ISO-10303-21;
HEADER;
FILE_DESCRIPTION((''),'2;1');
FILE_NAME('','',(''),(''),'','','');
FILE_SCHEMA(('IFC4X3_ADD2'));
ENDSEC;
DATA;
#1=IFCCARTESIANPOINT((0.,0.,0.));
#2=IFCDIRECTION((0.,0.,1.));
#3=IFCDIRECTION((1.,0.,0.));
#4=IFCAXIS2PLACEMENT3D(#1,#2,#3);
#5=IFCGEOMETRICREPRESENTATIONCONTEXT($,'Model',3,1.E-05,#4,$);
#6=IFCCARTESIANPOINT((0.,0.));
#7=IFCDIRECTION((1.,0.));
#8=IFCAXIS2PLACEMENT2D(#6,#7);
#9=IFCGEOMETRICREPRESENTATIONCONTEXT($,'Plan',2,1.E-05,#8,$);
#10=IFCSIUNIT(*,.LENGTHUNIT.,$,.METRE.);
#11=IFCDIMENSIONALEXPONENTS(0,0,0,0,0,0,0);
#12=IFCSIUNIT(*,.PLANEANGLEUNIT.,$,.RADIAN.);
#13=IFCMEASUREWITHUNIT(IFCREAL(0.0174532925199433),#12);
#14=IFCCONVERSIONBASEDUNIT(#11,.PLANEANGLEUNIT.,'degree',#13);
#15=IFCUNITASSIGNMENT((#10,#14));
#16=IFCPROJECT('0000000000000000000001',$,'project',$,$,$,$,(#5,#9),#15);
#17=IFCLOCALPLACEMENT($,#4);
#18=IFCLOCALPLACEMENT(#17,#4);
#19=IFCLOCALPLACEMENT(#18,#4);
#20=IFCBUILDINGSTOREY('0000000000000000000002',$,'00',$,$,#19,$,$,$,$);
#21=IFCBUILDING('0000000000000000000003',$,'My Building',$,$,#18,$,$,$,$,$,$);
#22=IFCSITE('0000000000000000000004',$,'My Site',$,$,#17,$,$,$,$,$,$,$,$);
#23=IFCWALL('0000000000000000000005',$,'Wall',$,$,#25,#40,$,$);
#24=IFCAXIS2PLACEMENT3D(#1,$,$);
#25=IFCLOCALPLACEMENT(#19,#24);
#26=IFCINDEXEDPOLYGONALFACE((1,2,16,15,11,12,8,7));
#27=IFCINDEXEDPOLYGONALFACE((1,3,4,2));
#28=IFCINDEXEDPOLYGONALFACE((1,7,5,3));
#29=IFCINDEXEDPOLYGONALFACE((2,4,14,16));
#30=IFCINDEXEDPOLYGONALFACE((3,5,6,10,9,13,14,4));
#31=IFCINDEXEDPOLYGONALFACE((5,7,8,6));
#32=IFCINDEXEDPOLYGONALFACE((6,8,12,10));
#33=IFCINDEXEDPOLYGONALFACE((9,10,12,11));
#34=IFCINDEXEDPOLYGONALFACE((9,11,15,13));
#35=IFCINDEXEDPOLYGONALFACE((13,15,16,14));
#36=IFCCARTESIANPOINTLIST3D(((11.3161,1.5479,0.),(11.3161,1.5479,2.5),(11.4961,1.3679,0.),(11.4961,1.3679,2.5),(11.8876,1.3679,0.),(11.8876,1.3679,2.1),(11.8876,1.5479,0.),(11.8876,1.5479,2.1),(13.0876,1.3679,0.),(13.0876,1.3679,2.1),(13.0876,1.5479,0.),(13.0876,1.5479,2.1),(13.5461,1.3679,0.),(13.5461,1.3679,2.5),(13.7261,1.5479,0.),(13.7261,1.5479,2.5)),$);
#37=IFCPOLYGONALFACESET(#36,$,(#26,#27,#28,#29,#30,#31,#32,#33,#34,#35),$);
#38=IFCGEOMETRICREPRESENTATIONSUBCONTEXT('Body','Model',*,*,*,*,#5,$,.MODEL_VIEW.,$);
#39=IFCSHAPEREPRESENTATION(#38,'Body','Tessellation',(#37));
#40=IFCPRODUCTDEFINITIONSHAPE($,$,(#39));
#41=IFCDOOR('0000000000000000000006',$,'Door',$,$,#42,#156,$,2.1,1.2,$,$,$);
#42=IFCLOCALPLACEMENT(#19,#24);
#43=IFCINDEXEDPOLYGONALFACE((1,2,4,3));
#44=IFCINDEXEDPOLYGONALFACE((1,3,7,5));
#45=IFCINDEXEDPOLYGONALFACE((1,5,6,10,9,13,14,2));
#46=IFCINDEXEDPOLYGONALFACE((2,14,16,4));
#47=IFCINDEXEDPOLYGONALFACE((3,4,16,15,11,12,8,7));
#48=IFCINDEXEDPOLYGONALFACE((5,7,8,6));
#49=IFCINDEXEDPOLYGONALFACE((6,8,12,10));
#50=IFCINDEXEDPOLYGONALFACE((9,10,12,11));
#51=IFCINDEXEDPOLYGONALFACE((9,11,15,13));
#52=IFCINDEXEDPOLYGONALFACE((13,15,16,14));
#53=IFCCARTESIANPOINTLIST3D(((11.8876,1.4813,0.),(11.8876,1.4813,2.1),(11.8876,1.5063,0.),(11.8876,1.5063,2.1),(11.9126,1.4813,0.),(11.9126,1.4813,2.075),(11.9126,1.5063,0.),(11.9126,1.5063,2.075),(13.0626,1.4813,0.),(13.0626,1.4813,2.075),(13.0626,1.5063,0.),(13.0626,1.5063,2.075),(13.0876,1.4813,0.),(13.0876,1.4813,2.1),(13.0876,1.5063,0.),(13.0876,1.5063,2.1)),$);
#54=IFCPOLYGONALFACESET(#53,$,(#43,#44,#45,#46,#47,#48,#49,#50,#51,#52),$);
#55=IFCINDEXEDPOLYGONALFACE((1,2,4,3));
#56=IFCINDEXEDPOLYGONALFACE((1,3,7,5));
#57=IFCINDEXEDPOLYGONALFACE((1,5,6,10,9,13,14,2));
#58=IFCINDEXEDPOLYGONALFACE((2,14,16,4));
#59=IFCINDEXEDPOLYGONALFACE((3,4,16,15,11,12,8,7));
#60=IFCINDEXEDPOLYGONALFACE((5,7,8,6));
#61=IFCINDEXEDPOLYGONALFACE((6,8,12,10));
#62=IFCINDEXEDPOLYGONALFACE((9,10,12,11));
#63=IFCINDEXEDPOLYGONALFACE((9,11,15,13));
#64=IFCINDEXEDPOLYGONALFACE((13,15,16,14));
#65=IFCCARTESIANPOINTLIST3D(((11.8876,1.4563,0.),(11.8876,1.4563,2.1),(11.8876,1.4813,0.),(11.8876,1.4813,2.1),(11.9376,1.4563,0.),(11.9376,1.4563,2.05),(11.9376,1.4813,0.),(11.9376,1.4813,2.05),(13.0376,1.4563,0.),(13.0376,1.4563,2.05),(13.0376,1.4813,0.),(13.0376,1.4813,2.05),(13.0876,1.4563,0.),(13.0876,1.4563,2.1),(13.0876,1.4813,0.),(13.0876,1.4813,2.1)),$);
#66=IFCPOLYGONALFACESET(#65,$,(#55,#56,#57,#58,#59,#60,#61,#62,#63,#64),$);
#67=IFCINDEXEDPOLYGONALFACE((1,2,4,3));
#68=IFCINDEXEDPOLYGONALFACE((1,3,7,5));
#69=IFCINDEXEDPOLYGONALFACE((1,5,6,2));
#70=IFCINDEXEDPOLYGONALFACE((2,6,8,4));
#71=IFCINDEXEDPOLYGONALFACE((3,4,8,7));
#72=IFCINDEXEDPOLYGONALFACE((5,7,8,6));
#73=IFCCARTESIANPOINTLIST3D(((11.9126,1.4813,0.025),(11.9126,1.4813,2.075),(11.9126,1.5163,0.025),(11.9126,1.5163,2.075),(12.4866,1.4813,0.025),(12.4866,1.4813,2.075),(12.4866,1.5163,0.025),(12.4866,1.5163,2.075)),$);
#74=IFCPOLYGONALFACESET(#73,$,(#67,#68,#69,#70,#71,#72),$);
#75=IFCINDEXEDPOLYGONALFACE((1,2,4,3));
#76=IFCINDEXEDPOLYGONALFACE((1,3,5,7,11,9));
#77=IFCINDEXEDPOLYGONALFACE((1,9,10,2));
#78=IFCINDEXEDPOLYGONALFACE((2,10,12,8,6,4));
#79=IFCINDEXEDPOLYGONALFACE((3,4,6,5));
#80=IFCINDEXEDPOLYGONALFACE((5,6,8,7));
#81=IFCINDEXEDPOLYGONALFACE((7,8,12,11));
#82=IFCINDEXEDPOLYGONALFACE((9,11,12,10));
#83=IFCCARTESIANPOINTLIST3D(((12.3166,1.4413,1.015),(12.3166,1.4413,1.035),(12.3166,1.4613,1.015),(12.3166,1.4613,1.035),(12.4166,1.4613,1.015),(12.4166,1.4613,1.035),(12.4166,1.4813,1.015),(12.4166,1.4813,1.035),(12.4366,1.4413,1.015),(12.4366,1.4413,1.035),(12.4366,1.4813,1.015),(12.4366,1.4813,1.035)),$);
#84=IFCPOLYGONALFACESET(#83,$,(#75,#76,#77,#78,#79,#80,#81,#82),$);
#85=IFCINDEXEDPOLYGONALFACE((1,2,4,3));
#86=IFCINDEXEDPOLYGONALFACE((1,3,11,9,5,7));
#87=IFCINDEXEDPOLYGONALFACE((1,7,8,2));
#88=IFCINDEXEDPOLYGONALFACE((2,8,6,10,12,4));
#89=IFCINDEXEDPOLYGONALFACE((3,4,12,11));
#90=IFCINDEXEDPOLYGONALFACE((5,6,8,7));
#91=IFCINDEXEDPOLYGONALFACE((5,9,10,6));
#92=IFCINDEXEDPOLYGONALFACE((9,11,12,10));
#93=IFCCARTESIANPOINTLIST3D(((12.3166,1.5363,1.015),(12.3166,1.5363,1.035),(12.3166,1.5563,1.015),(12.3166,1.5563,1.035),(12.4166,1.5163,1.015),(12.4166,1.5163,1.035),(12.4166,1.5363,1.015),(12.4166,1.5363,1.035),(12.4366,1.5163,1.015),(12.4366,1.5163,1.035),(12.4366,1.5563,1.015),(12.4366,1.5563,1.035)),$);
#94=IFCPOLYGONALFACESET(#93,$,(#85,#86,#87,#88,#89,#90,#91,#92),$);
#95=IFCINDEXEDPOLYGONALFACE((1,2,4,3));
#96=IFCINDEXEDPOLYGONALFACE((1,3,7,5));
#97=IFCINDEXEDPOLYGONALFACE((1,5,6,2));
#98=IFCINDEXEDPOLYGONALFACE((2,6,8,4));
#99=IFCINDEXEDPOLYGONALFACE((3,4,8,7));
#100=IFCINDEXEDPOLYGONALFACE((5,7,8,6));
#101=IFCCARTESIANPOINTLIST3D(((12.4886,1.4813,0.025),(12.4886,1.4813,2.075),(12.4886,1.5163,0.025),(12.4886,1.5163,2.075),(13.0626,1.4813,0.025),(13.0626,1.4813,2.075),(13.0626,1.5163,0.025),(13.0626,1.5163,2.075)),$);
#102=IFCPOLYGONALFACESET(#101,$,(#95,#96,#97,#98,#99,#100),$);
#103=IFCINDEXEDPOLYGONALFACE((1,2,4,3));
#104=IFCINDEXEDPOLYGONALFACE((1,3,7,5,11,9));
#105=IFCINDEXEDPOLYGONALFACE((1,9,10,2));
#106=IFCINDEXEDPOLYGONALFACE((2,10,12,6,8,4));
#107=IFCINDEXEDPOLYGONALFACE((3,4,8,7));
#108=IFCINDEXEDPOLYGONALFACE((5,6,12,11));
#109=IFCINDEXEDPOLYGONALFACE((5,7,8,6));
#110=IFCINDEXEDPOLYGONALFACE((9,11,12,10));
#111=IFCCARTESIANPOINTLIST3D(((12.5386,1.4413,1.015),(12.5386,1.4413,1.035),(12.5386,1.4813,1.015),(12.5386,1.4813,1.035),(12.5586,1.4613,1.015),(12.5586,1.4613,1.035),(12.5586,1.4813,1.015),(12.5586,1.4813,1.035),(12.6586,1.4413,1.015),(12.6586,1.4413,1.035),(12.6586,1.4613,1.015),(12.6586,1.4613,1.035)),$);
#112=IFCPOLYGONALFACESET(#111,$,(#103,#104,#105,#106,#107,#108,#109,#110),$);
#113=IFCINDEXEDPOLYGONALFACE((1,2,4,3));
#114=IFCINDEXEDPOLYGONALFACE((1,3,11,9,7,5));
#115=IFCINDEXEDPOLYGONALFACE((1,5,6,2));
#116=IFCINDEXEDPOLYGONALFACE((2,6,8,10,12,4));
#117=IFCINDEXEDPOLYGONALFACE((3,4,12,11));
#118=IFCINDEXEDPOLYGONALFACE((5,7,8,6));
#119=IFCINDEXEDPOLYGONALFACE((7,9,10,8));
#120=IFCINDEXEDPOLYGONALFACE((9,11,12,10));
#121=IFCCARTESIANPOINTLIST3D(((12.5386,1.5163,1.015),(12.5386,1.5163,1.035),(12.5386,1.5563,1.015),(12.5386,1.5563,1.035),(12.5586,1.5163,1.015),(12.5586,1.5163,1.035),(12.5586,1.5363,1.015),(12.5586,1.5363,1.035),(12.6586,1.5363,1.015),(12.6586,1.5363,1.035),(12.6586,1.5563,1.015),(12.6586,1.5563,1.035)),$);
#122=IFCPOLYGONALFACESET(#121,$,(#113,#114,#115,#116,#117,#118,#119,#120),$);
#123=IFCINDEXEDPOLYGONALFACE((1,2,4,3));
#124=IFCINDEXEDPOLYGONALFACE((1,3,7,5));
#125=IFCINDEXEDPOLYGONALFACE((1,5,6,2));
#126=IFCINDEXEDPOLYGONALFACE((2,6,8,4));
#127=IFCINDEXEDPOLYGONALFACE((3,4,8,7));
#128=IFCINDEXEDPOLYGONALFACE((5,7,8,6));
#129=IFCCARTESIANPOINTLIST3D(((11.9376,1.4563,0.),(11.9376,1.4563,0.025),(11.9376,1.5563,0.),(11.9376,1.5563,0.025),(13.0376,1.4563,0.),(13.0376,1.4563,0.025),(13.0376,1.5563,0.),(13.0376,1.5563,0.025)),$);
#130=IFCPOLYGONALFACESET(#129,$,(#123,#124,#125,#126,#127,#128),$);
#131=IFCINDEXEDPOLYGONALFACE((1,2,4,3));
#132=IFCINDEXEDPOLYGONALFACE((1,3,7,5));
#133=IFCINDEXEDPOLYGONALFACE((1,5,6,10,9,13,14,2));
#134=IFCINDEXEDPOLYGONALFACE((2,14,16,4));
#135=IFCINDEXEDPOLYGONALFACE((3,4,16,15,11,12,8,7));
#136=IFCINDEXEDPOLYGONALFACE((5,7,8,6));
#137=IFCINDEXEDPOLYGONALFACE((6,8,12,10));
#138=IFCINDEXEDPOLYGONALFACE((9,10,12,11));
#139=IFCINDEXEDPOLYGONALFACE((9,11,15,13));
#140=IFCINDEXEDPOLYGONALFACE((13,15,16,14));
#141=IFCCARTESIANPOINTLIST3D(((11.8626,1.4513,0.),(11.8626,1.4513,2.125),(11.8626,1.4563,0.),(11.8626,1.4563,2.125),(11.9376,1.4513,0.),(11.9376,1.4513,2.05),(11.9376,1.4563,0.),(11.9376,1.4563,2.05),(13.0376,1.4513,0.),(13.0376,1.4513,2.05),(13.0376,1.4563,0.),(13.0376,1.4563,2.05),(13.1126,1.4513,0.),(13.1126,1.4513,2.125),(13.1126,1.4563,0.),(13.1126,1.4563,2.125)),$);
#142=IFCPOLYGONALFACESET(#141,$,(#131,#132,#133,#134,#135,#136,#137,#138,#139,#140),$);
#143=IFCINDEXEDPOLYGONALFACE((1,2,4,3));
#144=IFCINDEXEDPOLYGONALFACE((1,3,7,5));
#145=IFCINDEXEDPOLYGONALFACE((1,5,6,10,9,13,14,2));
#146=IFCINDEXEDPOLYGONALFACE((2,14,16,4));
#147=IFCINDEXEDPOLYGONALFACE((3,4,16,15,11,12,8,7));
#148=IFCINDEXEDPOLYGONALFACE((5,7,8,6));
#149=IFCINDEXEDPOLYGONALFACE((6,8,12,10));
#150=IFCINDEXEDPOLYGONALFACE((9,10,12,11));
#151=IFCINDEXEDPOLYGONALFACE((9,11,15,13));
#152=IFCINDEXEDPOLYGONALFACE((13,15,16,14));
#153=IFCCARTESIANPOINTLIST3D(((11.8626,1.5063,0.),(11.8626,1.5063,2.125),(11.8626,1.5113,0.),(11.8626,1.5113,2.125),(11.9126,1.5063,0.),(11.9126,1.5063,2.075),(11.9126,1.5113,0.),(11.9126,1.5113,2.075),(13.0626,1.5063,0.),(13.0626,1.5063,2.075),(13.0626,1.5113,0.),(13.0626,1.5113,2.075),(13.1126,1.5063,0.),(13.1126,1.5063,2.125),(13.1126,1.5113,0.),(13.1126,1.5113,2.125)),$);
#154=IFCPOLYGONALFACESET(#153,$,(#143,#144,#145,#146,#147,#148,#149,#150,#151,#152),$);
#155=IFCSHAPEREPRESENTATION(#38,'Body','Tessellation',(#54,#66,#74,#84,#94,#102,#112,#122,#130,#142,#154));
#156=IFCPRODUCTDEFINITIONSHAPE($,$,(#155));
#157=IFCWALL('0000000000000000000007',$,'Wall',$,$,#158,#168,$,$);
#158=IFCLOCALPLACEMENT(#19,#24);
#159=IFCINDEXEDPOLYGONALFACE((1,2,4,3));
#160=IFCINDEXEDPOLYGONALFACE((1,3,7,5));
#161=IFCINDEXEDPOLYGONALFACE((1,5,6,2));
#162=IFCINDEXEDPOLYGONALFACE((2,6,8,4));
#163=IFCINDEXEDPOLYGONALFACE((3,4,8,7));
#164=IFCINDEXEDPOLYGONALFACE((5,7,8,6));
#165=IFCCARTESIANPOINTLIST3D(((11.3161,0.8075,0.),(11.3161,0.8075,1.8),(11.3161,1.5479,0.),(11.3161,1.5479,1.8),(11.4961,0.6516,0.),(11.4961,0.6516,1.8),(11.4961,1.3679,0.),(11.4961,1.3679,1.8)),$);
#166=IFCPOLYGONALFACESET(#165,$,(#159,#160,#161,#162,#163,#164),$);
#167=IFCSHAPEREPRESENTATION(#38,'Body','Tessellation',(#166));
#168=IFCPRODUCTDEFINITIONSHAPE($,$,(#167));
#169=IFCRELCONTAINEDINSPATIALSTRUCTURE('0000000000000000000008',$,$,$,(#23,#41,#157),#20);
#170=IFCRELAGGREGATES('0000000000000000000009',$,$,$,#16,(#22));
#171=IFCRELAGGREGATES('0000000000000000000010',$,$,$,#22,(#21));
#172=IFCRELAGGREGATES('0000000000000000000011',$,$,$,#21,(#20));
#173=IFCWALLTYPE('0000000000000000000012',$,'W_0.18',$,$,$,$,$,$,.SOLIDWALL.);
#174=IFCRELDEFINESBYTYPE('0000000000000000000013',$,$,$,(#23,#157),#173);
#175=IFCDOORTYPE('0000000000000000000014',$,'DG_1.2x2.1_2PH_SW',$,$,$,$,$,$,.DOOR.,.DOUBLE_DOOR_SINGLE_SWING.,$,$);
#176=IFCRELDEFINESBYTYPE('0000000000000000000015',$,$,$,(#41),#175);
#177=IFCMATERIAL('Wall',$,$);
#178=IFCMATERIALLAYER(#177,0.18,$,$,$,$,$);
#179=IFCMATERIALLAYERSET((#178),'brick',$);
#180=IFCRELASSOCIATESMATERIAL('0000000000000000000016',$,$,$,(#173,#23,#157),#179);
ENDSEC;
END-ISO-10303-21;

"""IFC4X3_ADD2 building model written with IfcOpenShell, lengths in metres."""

from ifc_helpers import new_model, entity, si_unit, converted_unit, frame, origin_with_axes, origin_2d_with_axis, place, context, subcontext, project, spatial, line, indexed_curve, outline, extrude, shape, source, transform, mapped, material, layer, layer_set, layer_usage, type_object, type_shapes, element, fill, save


model = new_model("IFC4X3_ADD2")

# Units and contexts
model_context = context("Model", 3, precision=1e-05, world=origin_with_axes())
plan_context = context("Plan", 2, precision=1e-05, world=origin_2d_with_axis())
body_context_1 = subcontext(model_context, "Body", "Model", "MODEL_VIEW")
body_context_2 = subcontext(plan_context, "Body", "Plan", "PLAN_VIEW")
ifc_project = project(units=[si_unit("LENGTHUNIT", "METRE"), converted_unit("PLANEANGLEUNIT", "degree", entity("IfcReal", 0.0174532925199433), si_unit("PLANEANGLEUNIT", "RADIAN"), dimensions=[0, 0, 0, 0, 0, 0, 0])], contexts=[model_context, plan_context])

# Site, building, storey
site_placement = place(None, origin_with_axes())
site = spatial("IfcSite", under=ifc_project, at=site_placement, Name="My Site")
building_placement = place(site_placement, origin_with_axes())
building = spatial("IfcBuilding", under=site, at=building_placement, Name="My Building")
storey_placement = place(building_placement, origin_with_axes())
storey = spatial("IfcBuildingStorey", under=building, at=storey_placement, Name="00")

# Shared definitions
ifc_material_1 = material(Name="Wall")
ifc_layer_1 = layer(ifc_material_1, 0.18)
ifc_layer_set_1 = layer_set([ifc_layer_1], Name="brick")
wall_type_1 = type_object("IfcWallType", Name="W_0.18", PredefinedType="SOLIDWALL", material=ifc_layer_set_1)

# Wall, opening, door
ifc_layer_usage_1 = layer_usage(ifc_layer_set_1, "AXIS2", "POSITIVE", 0.0)
wall_1_placement = place(storey_placement, frame((11.4961, 1.3679, 0.0), z_axis=(0.0, 0.0, 1.0), x_axis=(1.0, 0.0, 0.0)))
wall_1 = element("IfcWall", 1, at=wall_1_placement, inside=storey, type_object=wall_type_1, material=ifc_layer_usage_1, Name="Wall", context=body_context_1, shape_type="SweptSolid", body=[
    extrude(outline(indexed_curve([(0.0, 0.0), (-0.18, 0.18), (2.23, 0.18), (2.05, 0.0)], segments=[line(1, 2, 3, 4, 1)])), origin_with_axes(), (0.0, 0.0, 1.0), 2.5),
])
shared_shape_1 = source(origin_with_axes(), body_context_1, "Body", "SweptSolid", [
    extrude(outline(indexed_curve([(0.0, 0.0), (1.2, 0.0), (1.2, 2.1), (0.0, 2.1)], segments=[line(1, 2, 3, 4, 1)])), frame((0.0, -0.6, 0.0), z_axis=(0.0, -1.0, 0.0), x_axis=(1.0, 0.0, 0.0)), (0.0, 0.0, -1.0), 1.2),
])
opening_1_placement = place(wall_1_placement, frame((0.3915, 0.0885, 0.0), z_axis=(0.0, 0.0, 1.0), x_axis=(1.0, 0.0, 0.0)))
opening_1 = element("IfcOpeningElement", 2, at=opening_1_placement, cuts=wall_1, PredefinedType="OPENING", context=body_context_1, shape_type="MappedRepresentation", body=[
    mapped(shared_shape_1, transform((0.0, 0.0, 0.0), x_axis=(1.0, 0.0, 0.0), y_axis=(0.0, 1.0, 0.0), z_axis=(0.0, 0.0, 1.0), scale=1.0)),
])
door_type_1 = type_object("IfcDoorType", Name="DG_1.2x2.1_2PH_SW", OperationType="DOUBLE_DOOR_SINGLE_SWING", PredefinedType="DOOR")
shared_shape_2 = source(origin_with_axes(), body_context_1, "Body", "SweptSolid", [
    extrude(outline(indexed_curve([(0.0, 0.0), (0.0, 2.1), (1.2, 2.1), (1.2, 0.0), (1.175, 0.0), (1.175, 2.075), (0.025, 2.075), (0.025, 0.0)], segments=[line(1, 2, 3, 4, 5, 6, 7, 8, 1)])), frame((0.0, 0.025, 0.0), z_axis=(0.0, -1.0, 0.0), x_axis=(1.0, 0.0, 0.0)), (0.0, 0.0, -1.0), 0.025),
    extrude(outline(indexed_curve([(0.0, 0.0), (0.0, 2.1), (1.2, 2.1), (1.2, 0.0), (1.15, 0.0), (1.15, 2.05), (0.05, 2.05), (0.05, 0.0)], segments=[line(1, 2, 3, 4, 5, 6, 7, 8, 1)])), frame((0.0, 0.0, 0.0), z_axis=(0.0, -1.0, 0.0), x_axis=(1.0, 0.0, 0.0)), (0.0, 0.0, -1.0), 0.025),
    extrude(outline(indexed_curve([(0.0, 0.0), (0.574, 0.0), (0.574, 0.035), (0.0, 0.035)], segments=[line(1, 2, 3, 4, 1)])), frame((0.025, 0.025, 0.025), z_axis=(0.0, 0.0, 1.0), x_axis=(1.0, 0.0, 0.0)), (0.0, 0.0, 1.0), 2.05),
    extrude(outline(indexed_curve([(0.0, 0.0), (0.0, -0.04), (-0.12, -0.04), (-0.12, -0.02), (-0.02, -0.02), (-0.02, 0.0)], segments=[line(1, 2, 3, 4, 5, 6, 1)])), frame((0.549, 0.025, 1.015), z_axis=(0.0, 0.0, 1.0), x_axis=(1.0, 0.0, 0.0)), (0.0, 0.0, 1.0), 0.02),
    extrude(outline(indexed_curve([(0.0, 0.0), (0.0, 0.04), (-0.12, 0.04), (-0.12, 0.02), (-0.02, 0.02), (-0.02, 0.0)], segments=[line(1, 2, 3, 4, 5, 6, 1)])), frame((0.549, 0.06, 1.015), z_axis=(0.0, 0.0, 1.0), x_axis=(1.0, 0.0, 0.0)), (0.0, 0.0, 1.0), 0.02),
    extrude(outline(indexed_curve([(0.0, 0.0), (-0.574, 0.0), (-0.574, 0.035), (0.0, 0.035)], segments=[line(1, 2, 3, 4, 1)])), frame((1.175, 0.025, 0.025), z_axis=(0.0, 0.0, 1.0), x_axis=(1.0, 0.0, 0.0)), (0.0, 0.0, 1.0), 2.05),
    extrude(outline(indexed_curve([(0.0, 0.0), (0.0, -0.04), (0.12, -0.04), (0.12, -0.02), (0.02, -0.02), (0.02, 0.0)], segments=[line(1, 2, 3, 4, 5, 6, 1)])), frame((0.651, 0.025, 1.015), z_axis=(0.0, 0.0, 1.0), x_axis=(1.0, 0.0, 0.0)), (0.0, 0.0, 1.0), 0.02),
    extrude(outline(indexed_curve([(0.0, 0.0), (0.0, 0.04), (0.12, 0.04), (0.12, 0.02), (0.02, 0.02), (0.02, 0.0)], segments=[line(1, 2, 3, 4, 5, 6, 1)])), frame((0.651, 0.06, 1.015), z_axis=(0.0, 0.0, 1.0), x_axis=(1.0, 0.0, 0.0)), (0.0, 0.0, 1.0), 0.02),
    extrude(outline(indexed_curve([(0.0, 0.0), (1.1, 0.0), (1.1, 0.1), (0.0, 0.1)], segments=[line(1, 2, 3, 4, 1)])), frame((0.05, 0.0, 0.0), z_axis=(0.0, 0.0, 1.0), x_axis=(1.0, 0.0, 0.0)), (0.0, 0.0, 1.0), 0.025),
    extrude(outline(indexed_curve([(0.0, 0.0), (0.0, 2.125), (1.25, 2.125), (1.25, 0.0), (1.175, 0.0), (1.175, 2.05), (0.075, 2.05), (0.075, 0.0)], segments=[line(1, 2, 3, 4, 5, 6, 7, 8, 1)])), frame((-0.025, -0.005, 0.0), z_axis=(0.0, -1.0, 0.0), x_axis=(1.0, 0.0, 0.0)), (0.0, 0.0, -1.0), 0.005),
    extrude(outline(indexed_curve([(0.0, 0.0), (0.0, 2.125), (1.25, 2.125), (1.25, 0.0), (1.2, 0.0), (1.2, 2.075), (0.05, 2.075), (0.05, 0.0)], segments=[line(1, 2, 3, 4, 5, 6, 7, 8, 1)])), frame((-0.025, 0.05, 0.0), z_axis=(0.0, -1.0, 0.0), x_axis=(1.0, 0.0, 0.0)), (0.0, 0.0, -1.0), 0.005),
])
shared_shape_3 = source(origin_with_axes(), body_context_2, "Body", "Curve2D", [
    entity("IfcIndexedPolyCurve", entity("IfcCartesianPointList2D", [[0.0, 0.0], [0.0, 0.05], [0.025, 0.05], [0.025, 0.025], [0.05, 0.025], [0.05, 0.0]]), [entity("IfcLineIndex", [1, 2, 3, 4, 5, 6, 1])]),
    entity("IfcIndexedPolyCurve", entity("IfcCartesianPointList2D", [[1.2, 0.0], [1.2, 0.05], [1.175, 0.05], [1.175, 0.025], [1.15, 0.025], [1.15, 0.0]]), [entity("IfcLineIndex", [1, 2, 3, 4, 5, 6, 1])]),
    entity("IfcTrimmedCurve", entity("IfcEllipse", entity("IfcAxis2Placement2D", entity("IfcCartesianPoint", [0.06, 0.05]), entity("IfcDirection", [1.0, 0.0])), 0.54, 0.575), [entity("IfcCartesianPoint", [0.6, 0.05])], [entity("IfcCartesianPoint", [0.06, 0.625])], True, "CARTESIAN"),
    entity("IfcIndexedPolyCurve", entity("IfcCartesianPointList2D", [[0.025, 0.05], [0.06, 0.05], [0.06, 0.625], [0.025, 0.625]]), [entity("IfcLineIndex", [1, 2, 3, 4, 1])]),
    entity("IfcTrimmedCurve", entity("IfcEllipse", entity("IfcAxis2Placement2D", entity("IfcCartesianPoint", [1.14, 0.05]), entity("IfcDirection", [1.0, 0.0])), 0.54, 0.575), [entity("IfcCartesianPoint", [1.14, 0.625])], [entity("IfcCartesianPoint", [0.6, 0.05])], True, "CARTESIAN"),
    entity("IfcIndexedPolyCurve", entity("IfcCartesianPointList2D", [[1.175, 0.05], [1.14, 0.05], [1.14, 0.625], [1.175, 0.625]]), [entity("IfcLineIndex", [1, 2, 3, 4, 1])]),
])
type_shapes(door_type_1, [shared_shape_2, shared_shape_3])
door_1_placement = place(opening_1_placement, origin_with_axes())
door_1 = element("IfcDoor", 3, at=door_1_placement, inside=storey, type_object=door_type_1, Name="Door", OverallHeight=2.1, OverallWidth=1.2, shapes=[
    shape(body_context_1, "Body", "MappedRepresentation", [mapped(shared_shape_2, transform((0.0, 0.0, 0.0), x_axis=(1.0, 0.0, 0.0), y_axis=(0.0, 1.0, 0.0), z_axis=(0.0, 0.0, 1.0), scale=1.0))]),
    shape(body_context_2, "Body", "MappedRepresentation", [mapped(shared_shape_3, transform((0.0, 0.0, 0.0), x_axis=(1.0, 0.0, 0.0), y_axis=(0.0, 1.0, 0.0), z_axis=(0.0, 0.0, 1.0), scale=1.0))]),
])
fill(opening_1, door_1)

# Wall
ifc_layer_usage_2 = layer_usage(ifc_layer_set_1, "AXIS2", "POSITIVE", 0.0)
wall_2_placement = place(storey_placement, frame((11.4961, 0.6516, 0.0), z_axis=(0.0, 0.0, 1.0), x_axis=(0.000001, 1.0, 0.0)))
element("IfcWall", 4, at=wall_2_placement, inside=storey, type_object=wall_type_1, material=ifc_layer_usage_2, Name="Wall", context=body_context_1, shape_type="SweptSolid", body=[
    extrude(outline(indexed_curve([(0.0, 0.0), (0.1559, 0.18), (0.8963, 0.18), (0.7163, 0.0)], segments=[line(1, 2, 3, 4, 1)])), origin_with_axes(), (0.0, 0.0, 1.0), 1.8),
])

save(model, "model.ifc")
